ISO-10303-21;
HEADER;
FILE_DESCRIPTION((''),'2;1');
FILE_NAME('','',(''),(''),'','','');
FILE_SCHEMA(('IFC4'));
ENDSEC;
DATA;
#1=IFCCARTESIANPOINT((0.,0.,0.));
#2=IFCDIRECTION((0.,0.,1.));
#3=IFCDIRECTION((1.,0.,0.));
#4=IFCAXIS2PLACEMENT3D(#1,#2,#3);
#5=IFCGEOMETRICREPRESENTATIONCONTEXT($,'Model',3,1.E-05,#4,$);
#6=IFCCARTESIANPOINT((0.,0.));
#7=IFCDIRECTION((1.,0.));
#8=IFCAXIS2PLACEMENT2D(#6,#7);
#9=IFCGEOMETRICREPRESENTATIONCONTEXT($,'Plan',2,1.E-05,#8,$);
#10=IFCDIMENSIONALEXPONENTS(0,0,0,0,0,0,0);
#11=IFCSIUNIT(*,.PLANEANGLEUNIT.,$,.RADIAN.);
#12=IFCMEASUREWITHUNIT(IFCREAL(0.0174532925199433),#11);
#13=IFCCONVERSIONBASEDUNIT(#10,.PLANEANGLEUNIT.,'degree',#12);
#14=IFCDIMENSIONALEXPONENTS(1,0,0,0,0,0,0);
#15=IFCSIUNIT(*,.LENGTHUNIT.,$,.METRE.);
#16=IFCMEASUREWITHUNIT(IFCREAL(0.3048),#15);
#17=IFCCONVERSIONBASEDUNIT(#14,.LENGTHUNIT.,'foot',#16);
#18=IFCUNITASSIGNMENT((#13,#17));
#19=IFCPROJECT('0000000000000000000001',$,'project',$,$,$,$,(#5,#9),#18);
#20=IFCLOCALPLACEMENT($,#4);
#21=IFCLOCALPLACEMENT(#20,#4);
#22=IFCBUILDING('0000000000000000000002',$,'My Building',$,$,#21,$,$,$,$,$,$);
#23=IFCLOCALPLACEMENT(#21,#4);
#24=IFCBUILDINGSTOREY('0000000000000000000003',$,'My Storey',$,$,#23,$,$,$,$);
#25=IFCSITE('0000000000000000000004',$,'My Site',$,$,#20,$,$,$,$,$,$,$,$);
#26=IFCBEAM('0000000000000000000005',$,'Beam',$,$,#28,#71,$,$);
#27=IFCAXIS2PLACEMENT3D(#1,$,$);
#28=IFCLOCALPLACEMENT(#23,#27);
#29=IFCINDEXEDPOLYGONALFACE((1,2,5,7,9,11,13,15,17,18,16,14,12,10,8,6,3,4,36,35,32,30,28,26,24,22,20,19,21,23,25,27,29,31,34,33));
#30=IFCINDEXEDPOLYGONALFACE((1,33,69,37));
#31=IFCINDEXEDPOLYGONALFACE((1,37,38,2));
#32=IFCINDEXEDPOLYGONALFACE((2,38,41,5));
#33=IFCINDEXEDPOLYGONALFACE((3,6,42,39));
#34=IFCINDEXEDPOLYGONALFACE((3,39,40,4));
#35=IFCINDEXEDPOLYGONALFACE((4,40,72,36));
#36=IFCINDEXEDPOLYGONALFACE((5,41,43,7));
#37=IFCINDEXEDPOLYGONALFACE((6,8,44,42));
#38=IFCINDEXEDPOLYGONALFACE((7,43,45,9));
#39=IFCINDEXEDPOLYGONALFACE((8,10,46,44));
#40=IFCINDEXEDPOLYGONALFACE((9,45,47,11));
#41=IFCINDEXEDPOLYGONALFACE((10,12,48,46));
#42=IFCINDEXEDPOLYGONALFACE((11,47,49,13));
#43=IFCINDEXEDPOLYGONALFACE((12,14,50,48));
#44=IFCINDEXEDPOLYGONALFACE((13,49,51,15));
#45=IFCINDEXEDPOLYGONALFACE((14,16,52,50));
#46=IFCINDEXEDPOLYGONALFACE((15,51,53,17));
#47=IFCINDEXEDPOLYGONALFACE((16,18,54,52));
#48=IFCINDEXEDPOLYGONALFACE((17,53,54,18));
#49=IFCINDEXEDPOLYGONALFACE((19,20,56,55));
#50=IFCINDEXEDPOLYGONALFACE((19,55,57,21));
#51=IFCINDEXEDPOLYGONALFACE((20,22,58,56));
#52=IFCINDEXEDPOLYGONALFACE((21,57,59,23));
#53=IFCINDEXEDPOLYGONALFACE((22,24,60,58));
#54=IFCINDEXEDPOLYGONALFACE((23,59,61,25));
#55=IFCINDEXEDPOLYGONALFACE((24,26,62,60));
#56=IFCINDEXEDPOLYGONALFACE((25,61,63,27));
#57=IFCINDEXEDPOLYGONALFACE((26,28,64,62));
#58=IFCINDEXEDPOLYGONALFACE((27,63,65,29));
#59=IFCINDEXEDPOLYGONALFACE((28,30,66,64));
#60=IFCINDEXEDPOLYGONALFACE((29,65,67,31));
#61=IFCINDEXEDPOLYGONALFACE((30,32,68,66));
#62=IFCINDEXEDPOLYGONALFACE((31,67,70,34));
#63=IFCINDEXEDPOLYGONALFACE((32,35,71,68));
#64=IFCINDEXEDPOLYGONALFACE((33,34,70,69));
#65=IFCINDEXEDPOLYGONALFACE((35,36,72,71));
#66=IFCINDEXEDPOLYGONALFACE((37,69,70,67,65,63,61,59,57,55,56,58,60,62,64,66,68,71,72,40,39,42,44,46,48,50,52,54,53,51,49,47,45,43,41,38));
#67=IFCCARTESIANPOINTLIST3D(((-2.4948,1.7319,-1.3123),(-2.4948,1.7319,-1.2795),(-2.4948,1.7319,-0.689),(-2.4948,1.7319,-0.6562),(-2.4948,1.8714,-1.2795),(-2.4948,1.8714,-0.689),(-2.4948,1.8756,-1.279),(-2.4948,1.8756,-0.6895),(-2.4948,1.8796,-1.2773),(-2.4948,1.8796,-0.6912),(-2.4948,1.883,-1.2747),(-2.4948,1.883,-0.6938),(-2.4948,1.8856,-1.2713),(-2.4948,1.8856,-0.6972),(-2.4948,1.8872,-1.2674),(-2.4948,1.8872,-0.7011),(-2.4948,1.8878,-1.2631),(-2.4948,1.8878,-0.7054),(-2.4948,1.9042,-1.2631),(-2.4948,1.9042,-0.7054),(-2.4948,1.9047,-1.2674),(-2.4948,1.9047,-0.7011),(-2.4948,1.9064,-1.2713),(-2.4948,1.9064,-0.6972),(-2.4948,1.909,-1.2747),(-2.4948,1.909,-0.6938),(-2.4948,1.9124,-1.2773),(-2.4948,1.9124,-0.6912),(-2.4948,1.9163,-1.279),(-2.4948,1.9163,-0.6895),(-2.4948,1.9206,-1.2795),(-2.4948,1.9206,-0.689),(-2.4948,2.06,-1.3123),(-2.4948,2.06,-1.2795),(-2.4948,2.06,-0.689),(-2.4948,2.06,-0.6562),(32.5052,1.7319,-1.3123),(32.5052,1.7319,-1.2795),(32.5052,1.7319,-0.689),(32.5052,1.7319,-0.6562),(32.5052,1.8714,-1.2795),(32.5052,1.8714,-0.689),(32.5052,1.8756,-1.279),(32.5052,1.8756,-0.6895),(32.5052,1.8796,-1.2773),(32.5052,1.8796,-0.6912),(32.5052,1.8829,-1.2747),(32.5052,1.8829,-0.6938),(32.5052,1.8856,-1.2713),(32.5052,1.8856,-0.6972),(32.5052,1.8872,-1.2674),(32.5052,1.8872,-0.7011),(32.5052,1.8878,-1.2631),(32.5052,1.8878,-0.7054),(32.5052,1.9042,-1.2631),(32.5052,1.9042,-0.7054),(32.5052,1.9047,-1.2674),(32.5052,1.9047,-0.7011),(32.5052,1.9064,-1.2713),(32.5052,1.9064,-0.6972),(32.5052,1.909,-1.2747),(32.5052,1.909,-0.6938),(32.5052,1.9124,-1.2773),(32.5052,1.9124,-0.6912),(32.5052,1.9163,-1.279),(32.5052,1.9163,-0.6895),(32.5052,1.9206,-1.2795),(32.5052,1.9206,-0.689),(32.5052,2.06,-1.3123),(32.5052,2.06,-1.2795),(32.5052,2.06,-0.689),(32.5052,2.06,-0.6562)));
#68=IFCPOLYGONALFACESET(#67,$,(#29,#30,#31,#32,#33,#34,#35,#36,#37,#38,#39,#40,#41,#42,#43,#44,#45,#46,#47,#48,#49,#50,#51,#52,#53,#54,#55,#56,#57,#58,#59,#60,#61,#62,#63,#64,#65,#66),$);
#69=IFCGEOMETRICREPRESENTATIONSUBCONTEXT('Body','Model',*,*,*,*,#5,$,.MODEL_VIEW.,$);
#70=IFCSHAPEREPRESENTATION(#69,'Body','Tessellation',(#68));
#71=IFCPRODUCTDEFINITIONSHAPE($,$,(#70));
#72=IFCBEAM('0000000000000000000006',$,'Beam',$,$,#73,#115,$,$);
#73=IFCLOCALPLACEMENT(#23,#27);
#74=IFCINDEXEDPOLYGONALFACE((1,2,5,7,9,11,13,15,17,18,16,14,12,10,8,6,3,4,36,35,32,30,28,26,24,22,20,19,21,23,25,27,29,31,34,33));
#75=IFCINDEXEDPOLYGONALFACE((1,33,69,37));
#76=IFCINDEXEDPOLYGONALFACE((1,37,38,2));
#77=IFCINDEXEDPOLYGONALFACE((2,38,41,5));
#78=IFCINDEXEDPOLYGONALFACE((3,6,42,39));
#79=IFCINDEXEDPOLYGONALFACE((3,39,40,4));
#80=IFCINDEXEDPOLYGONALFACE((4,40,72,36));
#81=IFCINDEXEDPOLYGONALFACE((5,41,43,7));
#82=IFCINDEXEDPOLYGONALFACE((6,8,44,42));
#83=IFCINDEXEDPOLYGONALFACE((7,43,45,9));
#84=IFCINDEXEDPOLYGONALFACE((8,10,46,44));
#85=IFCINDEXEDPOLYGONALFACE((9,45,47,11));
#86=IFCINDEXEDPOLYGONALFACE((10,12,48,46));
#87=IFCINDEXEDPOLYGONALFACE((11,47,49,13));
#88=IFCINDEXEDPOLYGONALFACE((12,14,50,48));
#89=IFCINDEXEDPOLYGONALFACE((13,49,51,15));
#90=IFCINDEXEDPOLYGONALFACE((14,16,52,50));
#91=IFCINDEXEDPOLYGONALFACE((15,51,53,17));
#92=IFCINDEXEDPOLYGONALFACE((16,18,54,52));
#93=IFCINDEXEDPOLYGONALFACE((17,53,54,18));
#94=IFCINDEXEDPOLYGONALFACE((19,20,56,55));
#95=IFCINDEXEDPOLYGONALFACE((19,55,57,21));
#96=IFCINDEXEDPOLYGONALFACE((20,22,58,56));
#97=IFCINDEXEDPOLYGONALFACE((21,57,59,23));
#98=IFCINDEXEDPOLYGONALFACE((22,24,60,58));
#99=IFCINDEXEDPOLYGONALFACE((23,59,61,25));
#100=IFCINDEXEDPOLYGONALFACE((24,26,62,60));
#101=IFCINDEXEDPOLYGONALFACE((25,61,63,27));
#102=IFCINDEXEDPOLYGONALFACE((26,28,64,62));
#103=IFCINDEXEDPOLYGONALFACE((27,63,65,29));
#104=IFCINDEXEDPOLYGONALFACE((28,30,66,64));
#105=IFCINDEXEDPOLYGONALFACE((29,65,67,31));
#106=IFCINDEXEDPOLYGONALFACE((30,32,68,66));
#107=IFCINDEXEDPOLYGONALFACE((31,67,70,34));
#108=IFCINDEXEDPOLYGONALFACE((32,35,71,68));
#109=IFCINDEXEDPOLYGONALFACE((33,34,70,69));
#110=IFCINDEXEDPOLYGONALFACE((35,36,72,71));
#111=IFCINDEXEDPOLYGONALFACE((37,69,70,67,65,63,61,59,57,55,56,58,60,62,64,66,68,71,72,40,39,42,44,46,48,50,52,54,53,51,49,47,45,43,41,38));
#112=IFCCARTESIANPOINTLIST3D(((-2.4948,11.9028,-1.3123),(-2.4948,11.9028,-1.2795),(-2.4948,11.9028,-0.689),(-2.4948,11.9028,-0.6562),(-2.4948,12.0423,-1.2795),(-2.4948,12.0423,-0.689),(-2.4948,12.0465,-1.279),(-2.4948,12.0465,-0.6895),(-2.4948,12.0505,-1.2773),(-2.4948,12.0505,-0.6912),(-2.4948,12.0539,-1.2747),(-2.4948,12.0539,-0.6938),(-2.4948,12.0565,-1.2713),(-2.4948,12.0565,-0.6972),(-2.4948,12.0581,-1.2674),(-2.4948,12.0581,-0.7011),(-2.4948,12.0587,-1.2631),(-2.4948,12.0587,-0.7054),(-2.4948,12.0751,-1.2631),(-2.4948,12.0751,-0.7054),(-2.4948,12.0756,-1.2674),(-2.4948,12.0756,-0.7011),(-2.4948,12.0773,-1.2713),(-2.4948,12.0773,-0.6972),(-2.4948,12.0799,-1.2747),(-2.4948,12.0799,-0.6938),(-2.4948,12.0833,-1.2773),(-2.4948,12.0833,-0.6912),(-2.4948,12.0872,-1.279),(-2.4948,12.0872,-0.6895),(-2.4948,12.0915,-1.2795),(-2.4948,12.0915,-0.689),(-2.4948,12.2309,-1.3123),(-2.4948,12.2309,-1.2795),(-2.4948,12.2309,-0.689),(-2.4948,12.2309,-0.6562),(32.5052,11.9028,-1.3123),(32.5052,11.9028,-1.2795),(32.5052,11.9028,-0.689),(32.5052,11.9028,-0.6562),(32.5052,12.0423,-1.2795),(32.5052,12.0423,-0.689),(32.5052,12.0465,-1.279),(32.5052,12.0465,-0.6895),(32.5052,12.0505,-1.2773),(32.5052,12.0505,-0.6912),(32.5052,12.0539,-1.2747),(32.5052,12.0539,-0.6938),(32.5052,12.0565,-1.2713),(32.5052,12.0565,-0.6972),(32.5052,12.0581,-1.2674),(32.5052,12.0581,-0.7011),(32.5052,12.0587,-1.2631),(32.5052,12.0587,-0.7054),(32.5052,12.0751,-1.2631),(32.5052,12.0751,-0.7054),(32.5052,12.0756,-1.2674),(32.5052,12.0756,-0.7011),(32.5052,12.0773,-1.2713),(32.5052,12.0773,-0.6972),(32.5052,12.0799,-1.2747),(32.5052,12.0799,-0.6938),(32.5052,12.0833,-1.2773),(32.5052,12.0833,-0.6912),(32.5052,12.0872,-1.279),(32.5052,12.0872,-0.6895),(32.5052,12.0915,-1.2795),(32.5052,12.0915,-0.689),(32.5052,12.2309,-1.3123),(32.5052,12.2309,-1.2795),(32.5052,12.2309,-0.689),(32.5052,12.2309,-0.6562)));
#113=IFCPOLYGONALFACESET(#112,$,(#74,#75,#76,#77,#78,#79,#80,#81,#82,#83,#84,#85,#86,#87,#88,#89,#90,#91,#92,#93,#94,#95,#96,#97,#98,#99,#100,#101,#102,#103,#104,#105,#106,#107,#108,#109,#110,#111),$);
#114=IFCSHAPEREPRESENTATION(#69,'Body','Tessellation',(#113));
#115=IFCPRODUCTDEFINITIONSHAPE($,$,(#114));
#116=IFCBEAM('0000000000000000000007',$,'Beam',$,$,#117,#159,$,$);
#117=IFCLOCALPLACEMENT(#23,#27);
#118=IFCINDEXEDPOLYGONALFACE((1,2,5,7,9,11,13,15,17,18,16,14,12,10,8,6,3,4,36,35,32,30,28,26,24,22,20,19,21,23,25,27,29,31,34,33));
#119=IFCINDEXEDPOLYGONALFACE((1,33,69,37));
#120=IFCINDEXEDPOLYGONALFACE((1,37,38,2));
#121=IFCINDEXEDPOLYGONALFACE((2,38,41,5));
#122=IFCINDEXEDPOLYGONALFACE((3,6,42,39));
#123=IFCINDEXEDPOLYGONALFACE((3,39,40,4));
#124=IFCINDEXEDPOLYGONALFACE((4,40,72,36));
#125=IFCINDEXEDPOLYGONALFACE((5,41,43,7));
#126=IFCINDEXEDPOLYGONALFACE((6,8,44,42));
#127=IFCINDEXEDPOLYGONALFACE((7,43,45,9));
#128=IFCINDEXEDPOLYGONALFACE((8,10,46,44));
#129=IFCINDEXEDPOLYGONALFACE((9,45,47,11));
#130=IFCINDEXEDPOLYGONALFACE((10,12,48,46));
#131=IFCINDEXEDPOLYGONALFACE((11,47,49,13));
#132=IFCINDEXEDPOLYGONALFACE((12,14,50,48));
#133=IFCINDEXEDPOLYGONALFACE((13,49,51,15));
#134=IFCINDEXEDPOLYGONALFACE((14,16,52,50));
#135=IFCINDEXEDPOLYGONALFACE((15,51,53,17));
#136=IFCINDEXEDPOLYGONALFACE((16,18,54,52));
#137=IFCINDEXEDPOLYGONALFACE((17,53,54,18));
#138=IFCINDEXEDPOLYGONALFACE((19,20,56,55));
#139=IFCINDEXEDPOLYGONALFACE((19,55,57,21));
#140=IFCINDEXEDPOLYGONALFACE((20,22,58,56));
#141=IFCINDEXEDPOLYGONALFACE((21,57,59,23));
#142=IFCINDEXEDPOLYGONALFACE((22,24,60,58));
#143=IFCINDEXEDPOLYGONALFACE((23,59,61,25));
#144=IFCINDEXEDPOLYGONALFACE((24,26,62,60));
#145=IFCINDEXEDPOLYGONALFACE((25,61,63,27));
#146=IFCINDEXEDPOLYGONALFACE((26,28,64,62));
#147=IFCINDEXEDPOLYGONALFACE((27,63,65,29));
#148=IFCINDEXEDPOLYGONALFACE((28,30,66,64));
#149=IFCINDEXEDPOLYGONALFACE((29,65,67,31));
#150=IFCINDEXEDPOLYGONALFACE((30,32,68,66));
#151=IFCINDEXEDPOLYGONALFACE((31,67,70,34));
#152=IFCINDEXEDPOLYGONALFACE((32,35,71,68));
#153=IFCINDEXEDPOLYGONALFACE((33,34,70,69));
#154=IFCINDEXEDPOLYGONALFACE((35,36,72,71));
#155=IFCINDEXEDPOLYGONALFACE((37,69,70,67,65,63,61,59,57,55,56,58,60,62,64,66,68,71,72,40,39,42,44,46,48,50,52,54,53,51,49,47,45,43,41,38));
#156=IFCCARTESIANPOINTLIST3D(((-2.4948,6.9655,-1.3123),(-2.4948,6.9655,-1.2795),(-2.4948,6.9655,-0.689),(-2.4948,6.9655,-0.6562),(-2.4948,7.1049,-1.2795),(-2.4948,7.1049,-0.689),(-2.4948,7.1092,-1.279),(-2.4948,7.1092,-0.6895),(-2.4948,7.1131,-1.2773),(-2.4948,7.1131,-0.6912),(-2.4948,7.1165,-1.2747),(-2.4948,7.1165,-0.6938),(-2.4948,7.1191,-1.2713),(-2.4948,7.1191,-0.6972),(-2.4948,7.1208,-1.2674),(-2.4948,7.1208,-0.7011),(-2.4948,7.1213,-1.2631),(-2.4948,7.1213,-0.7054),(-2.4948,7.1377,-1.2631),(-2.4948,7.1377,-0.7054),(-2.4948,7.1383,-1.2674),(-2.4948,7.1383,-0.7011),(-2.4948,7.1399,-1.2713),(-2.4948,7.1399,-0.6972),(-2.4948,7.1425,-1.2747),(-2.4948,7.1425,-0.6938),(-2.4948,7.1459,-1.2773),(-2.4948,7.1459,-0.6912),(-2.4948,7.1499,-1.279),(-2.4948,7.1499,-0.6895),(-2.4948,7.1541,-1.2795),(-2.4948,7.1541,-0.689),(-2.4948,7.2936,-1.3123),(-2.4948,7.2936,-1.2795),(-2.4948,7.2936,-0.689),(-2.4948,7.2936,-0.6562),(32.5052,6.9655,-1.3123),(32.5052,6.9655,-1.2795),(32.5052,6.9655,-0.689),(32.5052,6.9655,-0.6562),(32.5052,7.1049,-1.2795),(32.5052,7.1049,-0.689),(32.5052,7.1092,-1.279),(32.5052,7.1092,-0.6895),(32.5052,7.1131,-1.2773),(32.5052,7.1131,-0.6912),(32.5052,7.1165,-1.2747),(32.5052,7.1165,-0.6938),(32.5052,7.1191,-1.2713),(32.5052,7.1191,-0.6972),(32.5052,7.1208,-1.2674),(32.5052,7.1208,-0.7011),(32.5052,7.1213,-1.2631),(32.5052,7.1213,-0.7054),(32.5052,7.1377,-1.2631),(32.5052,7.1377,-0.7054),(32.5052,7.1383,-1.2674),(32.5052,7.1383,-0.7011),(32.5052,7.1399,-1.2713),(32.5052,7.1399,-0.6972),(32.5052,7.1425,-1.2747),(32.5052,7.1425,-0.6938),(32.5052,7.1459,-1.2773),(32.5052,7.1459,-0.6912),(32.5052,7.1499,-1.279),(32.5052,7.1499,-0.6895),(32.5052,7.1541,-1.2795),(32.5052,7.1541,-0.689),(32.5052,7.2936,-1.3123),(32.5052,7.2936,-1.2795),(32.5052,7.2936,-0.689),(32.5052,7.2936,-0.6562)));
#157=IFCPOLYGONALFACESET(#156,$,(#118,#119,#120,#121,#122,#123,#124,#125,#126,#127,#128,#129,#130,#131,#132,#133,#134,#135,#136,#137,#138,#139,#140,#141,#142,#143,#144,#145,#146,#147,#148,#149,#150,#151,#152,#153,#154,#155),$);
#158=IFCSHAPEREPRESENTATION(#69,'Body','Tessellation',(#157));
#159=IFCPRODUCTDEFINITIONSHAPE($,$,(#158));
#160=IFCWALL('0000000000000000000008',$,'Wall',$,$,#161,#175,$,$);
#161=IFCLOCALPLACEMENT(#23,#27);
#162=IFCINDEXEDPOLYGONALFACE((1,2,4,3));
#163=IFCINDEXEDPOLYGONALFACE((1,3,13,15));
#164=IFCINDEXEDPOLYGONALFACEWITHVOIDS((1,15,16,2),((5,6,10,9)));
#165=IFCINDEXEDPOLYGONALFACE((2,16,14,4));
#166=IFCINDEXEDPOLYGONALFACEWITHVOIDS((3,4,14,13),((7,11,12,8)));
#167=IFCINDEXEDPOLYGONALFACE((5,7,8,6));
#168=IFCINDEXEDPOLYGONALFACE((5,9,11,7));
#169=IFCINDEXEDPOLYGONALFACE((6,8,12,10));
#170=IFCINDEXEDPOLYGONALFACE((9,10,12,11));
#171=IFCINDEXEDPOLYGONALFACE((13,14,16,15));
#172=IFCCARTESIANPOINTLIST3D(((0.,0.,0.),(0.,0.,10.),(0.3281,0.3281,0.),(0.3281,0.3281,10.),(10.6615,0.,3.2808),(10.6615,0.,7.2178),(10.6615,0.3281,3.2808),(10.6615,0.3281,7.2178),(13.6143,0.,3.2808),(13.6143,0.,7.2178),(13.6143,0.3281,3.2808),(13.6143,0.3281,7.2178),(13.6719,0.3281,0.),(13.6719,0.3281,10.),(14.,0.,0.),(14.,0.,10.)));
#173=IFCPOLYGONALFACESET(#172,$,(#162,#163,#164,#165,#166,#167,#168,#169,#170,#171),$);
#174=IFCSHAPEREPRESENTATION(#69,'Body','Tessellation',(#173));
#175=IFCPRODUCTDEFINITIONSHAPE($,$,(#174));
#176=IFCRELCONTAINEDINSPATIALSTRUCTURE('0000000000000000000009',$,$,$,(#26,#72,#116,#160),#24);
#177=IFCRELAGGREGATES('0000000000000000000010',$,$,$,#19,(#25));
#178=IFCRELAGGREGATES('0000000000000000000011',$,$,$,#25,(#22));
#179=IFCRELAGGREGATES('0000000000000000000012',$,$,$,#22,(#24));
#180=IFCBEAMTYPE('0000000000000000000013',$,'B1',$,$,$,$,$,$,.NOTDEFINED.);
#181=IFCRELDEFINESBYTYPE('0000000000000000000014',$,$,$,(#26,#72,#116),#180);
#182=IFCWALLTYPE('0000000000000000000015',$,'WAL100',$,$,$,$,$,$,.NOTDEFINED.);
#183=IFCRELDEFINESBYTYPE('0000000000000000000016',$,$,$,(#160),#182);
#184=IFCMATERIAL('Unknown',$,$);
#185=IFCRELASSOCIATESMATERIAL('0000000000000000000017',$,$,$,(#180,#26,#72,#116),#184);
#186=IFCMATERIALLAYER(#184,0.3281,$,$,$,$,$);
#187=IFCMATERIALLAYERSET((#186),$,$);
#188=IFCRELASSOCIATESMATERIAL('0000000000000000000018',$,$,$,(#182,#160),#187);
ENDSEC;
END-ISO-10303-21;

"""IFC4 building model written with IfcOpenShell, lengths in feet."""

from ifc_helpers import new_model, entity, si_unit, converted_unit, frame, origin_with_axes, origin_2d_with_axis, place, context, subcontext, project, spatial, line, indexed_curve, i_section, outline, extrude, clip, halfspace, source, transform, mapped, material, layer, layer_set, layer_usage, material_profile, profile_set, profile_usage, type_object, element, save


model = new_model("IFC4")

# Units and contexts
model_context = context("Model", 3, precision=1e-05, world=origin_with_axes())
plan_context = context("Plan", 2, precision=1e-05, world=origin_2d_with_axis())
body_context_1 = subcontext(model_context, "Body", "Model", "MODEL_VIEW")
ifc_project = project(units=[converted_unit("PLANEANGLEUNIT", "degree", entity("IfcReal", 0.0174532925199433), si_unit("PLANEANGLEUNIT", "RADIAN"), dimensions=[0, 0, 0, 0, 0, 0, 0]), converted_unit("LENGTHUNIT", "foot", entity("IfcReal", 0.3048), si_unit("LENGTHUNIT", "METRE"), dimensions=[1, 0, 0, 0, 0, 0, 0])], contexts=[model_context, plan_context])

# Site, building, storey
site_placement = place(None, origin_with_axes())
site = spatial("IfcSite", under=ifc_project, at=site_placement, Name="My Site")
building_placement = place(site_placement, origin_with_axes())
building = spatial("IfcBuilding", under=site, at=building_placement, Name="My Building")
storey_placement = place(building_placement, origin_with_axes())
storey = spatial("IfcBuildingStorey", under=building, at=storey_placement, Name="My Storey")

# Shared definitions
ifc_material = material(Name="Unknown")

# Beams
ifc_material_profile_1 = material_profile(ifc_material, i_section(OverallWidth=0.3281, OverallDepth=0.6562, WebThickness=0.0164, FlangeThickness=0.0328, FilletRadius=0.0164))
ifc_profile_set_1 = profile_set([ifc_material_profile_1])
ifc_profile_usage_1 = profile_usage(ifc_profile_set_1, cardinal=5)
beam_type = type_object("IfcBeamType", Name="B1", PredefinedType="NOTDEFINED", material=ifc_profile_set_1)
beam_1_placement = place(storey_placement, frame((-2.4948, 1.896, -0.9843), z_axis=(1.0, 0.0, 0.0), x_axis=(0.0, 1.0, 0.0)))
element("IfcBeam", 1, at=beam_1_placement, inside=storey, type_object=beam_type, material=ifc_profile_usage_1, Name="Beam", context=body_context_1, shape_type="SweptSolid", body=[
    extrude(i_section(OverallWidth=0.3281, OverallDepth=0.6562, WebThickness=0.0164, FlangeThickness=0.0328, FilletRadius=0.0164), origin_with_axes(), (0.0, 0.0, 1.0), 35.0),
])
ifc_profile_usage_2 = profile_usage(ifc_profile_set_1, cardinal=5)
beam_2_placement = place(storey_placement, frame((-2.4948, 12.0669, -0.9843), z_axis=(1.0, 0.0, 0.0), x_axis=(0.0, 1.0, 0.0)))
element("IfcBeam", 2, at=beam_2_placement, inside=storey, type_object=beam_type, material=ifc_profile_usage_2, Name="Beam", context=body_context_1, shape_type="SweptSolid", body=[
    extrude(i_section(OverallWidth=0.3281, OverallDepth=0.6562, WebThickness=0.0164, FlangeThickness=0.0328, FilletRadius=0.0164), origin_with_axes(), (0.0, 0.0, 1.0), 35.0),
])
ifc_profile_usage_3 = profile_usage(ifc_profile_set_1, cardinal=5)
beam_3_placement = place(storey_placement, frame((-2.4948, 7.1295, -0.9843), z_axis=(1.0, 0.0, 0.0), x_axis=(0.0, 1.0, 0.0)))
element("IfcBeam", 3, at=beam_3_placement, inside=storey, type_object=beam_type, material=ifc_profile_usage_3, Name="Beam", context=body_context_1, shape_type="SweptSolid", body=[
    extrude(i_section(OverallWidth=0.3281, OverallDepth=0.6562, WebThickness=0.0164, FlangeThickness=0.0328, FilletRadius=0.0164), origin_with_axes(), (0.0, 0.0, 1.0), 35.0),
])

# Wall, opening
ifc_layer_1 = layer(ifc_material, 0.3281)
ifc_layer_set_1 = layer_set([ifc_layer_1])
ifc_layer_usage_1 = layer_usage(ifc_layer_set_1, "AXIS2", "POSITIVE", 0.0)
wall_type = type_object("IfcWallType", Name="WAL100", PredefinedType="NOTDEFINED", material=ifc_layer_set_1)
wall_1_placement = place(storey_placement, origin_with_axes())
wall_1 = element("IfcWall", 4, at=wall_1_placement, inside=storey, type_object=wall_type, material=ifc_layer_usage_1, Name="Wall", context=body_context_1, shape_type="Clipping", body=[
    clip(clip(extrude(outline(indexed_curve([(0.0, 0.0), (0.0, 0.3281), (14.0, 0.3281), (14.0, 0.0), (0.0, 0.0)], self_intersect=False)), origin_with_axes(), (0.0, 0.0, 1.0), 10.0), halfspace(frame((14.0, 0.0, 0.0), z_axis=(0.707107, 0.707106, 0.0), x_axis=(0.707106, -0.707107, 0.0)), False)), halfspace(frame((0.0, 0.0, 0.0), z_axis=(-0.707107, 0.707107, 0.0), x_axis=(0.707107, 0.707107, 0.0)), False)),
])
shared_shape_1 = source(origin_with_axes(), body_context_1, "Body", "SweptSolid", [
    extrude(outline(indexed_curve([(0.0, 0.0), (2.9528, 0.0), (2.9528, 3.937), (0.0, 3.937)], segments=[line(1, 2, 3, 4, 1)])), frame((0.0, -1.9685, 0.0), z_axis=(0.0, -1.0, 0.0), x_axis=(1.0, 0.0, 0.0)), (0.0, 0.0, -1.0), 3.937),
])
opening_1_placement = place(wall_1_placement, frame((10.6615, 0.0, 3.2808), z_axis=(0.0, 0.0, 1.0), x_axis=(1.0, 0.0, 0.0)))
element("IfcOpeningElement", 5, at=opening_1_placement, cuts=wall_1, PredefinedType="OPENING", context=body_context_1, shape_type="MappedRepresentation", body=[
    mapped(shared_shape_1, transform((0.0, 0.0, 0.0), x_axis=(1.0, 0.0, 0.0), y_axis=(0.0, 1.0, 0.0), z_axis=(0.0, 0.0, 1.0), scale=1.0)),
])

save(model, "model.ifc")
